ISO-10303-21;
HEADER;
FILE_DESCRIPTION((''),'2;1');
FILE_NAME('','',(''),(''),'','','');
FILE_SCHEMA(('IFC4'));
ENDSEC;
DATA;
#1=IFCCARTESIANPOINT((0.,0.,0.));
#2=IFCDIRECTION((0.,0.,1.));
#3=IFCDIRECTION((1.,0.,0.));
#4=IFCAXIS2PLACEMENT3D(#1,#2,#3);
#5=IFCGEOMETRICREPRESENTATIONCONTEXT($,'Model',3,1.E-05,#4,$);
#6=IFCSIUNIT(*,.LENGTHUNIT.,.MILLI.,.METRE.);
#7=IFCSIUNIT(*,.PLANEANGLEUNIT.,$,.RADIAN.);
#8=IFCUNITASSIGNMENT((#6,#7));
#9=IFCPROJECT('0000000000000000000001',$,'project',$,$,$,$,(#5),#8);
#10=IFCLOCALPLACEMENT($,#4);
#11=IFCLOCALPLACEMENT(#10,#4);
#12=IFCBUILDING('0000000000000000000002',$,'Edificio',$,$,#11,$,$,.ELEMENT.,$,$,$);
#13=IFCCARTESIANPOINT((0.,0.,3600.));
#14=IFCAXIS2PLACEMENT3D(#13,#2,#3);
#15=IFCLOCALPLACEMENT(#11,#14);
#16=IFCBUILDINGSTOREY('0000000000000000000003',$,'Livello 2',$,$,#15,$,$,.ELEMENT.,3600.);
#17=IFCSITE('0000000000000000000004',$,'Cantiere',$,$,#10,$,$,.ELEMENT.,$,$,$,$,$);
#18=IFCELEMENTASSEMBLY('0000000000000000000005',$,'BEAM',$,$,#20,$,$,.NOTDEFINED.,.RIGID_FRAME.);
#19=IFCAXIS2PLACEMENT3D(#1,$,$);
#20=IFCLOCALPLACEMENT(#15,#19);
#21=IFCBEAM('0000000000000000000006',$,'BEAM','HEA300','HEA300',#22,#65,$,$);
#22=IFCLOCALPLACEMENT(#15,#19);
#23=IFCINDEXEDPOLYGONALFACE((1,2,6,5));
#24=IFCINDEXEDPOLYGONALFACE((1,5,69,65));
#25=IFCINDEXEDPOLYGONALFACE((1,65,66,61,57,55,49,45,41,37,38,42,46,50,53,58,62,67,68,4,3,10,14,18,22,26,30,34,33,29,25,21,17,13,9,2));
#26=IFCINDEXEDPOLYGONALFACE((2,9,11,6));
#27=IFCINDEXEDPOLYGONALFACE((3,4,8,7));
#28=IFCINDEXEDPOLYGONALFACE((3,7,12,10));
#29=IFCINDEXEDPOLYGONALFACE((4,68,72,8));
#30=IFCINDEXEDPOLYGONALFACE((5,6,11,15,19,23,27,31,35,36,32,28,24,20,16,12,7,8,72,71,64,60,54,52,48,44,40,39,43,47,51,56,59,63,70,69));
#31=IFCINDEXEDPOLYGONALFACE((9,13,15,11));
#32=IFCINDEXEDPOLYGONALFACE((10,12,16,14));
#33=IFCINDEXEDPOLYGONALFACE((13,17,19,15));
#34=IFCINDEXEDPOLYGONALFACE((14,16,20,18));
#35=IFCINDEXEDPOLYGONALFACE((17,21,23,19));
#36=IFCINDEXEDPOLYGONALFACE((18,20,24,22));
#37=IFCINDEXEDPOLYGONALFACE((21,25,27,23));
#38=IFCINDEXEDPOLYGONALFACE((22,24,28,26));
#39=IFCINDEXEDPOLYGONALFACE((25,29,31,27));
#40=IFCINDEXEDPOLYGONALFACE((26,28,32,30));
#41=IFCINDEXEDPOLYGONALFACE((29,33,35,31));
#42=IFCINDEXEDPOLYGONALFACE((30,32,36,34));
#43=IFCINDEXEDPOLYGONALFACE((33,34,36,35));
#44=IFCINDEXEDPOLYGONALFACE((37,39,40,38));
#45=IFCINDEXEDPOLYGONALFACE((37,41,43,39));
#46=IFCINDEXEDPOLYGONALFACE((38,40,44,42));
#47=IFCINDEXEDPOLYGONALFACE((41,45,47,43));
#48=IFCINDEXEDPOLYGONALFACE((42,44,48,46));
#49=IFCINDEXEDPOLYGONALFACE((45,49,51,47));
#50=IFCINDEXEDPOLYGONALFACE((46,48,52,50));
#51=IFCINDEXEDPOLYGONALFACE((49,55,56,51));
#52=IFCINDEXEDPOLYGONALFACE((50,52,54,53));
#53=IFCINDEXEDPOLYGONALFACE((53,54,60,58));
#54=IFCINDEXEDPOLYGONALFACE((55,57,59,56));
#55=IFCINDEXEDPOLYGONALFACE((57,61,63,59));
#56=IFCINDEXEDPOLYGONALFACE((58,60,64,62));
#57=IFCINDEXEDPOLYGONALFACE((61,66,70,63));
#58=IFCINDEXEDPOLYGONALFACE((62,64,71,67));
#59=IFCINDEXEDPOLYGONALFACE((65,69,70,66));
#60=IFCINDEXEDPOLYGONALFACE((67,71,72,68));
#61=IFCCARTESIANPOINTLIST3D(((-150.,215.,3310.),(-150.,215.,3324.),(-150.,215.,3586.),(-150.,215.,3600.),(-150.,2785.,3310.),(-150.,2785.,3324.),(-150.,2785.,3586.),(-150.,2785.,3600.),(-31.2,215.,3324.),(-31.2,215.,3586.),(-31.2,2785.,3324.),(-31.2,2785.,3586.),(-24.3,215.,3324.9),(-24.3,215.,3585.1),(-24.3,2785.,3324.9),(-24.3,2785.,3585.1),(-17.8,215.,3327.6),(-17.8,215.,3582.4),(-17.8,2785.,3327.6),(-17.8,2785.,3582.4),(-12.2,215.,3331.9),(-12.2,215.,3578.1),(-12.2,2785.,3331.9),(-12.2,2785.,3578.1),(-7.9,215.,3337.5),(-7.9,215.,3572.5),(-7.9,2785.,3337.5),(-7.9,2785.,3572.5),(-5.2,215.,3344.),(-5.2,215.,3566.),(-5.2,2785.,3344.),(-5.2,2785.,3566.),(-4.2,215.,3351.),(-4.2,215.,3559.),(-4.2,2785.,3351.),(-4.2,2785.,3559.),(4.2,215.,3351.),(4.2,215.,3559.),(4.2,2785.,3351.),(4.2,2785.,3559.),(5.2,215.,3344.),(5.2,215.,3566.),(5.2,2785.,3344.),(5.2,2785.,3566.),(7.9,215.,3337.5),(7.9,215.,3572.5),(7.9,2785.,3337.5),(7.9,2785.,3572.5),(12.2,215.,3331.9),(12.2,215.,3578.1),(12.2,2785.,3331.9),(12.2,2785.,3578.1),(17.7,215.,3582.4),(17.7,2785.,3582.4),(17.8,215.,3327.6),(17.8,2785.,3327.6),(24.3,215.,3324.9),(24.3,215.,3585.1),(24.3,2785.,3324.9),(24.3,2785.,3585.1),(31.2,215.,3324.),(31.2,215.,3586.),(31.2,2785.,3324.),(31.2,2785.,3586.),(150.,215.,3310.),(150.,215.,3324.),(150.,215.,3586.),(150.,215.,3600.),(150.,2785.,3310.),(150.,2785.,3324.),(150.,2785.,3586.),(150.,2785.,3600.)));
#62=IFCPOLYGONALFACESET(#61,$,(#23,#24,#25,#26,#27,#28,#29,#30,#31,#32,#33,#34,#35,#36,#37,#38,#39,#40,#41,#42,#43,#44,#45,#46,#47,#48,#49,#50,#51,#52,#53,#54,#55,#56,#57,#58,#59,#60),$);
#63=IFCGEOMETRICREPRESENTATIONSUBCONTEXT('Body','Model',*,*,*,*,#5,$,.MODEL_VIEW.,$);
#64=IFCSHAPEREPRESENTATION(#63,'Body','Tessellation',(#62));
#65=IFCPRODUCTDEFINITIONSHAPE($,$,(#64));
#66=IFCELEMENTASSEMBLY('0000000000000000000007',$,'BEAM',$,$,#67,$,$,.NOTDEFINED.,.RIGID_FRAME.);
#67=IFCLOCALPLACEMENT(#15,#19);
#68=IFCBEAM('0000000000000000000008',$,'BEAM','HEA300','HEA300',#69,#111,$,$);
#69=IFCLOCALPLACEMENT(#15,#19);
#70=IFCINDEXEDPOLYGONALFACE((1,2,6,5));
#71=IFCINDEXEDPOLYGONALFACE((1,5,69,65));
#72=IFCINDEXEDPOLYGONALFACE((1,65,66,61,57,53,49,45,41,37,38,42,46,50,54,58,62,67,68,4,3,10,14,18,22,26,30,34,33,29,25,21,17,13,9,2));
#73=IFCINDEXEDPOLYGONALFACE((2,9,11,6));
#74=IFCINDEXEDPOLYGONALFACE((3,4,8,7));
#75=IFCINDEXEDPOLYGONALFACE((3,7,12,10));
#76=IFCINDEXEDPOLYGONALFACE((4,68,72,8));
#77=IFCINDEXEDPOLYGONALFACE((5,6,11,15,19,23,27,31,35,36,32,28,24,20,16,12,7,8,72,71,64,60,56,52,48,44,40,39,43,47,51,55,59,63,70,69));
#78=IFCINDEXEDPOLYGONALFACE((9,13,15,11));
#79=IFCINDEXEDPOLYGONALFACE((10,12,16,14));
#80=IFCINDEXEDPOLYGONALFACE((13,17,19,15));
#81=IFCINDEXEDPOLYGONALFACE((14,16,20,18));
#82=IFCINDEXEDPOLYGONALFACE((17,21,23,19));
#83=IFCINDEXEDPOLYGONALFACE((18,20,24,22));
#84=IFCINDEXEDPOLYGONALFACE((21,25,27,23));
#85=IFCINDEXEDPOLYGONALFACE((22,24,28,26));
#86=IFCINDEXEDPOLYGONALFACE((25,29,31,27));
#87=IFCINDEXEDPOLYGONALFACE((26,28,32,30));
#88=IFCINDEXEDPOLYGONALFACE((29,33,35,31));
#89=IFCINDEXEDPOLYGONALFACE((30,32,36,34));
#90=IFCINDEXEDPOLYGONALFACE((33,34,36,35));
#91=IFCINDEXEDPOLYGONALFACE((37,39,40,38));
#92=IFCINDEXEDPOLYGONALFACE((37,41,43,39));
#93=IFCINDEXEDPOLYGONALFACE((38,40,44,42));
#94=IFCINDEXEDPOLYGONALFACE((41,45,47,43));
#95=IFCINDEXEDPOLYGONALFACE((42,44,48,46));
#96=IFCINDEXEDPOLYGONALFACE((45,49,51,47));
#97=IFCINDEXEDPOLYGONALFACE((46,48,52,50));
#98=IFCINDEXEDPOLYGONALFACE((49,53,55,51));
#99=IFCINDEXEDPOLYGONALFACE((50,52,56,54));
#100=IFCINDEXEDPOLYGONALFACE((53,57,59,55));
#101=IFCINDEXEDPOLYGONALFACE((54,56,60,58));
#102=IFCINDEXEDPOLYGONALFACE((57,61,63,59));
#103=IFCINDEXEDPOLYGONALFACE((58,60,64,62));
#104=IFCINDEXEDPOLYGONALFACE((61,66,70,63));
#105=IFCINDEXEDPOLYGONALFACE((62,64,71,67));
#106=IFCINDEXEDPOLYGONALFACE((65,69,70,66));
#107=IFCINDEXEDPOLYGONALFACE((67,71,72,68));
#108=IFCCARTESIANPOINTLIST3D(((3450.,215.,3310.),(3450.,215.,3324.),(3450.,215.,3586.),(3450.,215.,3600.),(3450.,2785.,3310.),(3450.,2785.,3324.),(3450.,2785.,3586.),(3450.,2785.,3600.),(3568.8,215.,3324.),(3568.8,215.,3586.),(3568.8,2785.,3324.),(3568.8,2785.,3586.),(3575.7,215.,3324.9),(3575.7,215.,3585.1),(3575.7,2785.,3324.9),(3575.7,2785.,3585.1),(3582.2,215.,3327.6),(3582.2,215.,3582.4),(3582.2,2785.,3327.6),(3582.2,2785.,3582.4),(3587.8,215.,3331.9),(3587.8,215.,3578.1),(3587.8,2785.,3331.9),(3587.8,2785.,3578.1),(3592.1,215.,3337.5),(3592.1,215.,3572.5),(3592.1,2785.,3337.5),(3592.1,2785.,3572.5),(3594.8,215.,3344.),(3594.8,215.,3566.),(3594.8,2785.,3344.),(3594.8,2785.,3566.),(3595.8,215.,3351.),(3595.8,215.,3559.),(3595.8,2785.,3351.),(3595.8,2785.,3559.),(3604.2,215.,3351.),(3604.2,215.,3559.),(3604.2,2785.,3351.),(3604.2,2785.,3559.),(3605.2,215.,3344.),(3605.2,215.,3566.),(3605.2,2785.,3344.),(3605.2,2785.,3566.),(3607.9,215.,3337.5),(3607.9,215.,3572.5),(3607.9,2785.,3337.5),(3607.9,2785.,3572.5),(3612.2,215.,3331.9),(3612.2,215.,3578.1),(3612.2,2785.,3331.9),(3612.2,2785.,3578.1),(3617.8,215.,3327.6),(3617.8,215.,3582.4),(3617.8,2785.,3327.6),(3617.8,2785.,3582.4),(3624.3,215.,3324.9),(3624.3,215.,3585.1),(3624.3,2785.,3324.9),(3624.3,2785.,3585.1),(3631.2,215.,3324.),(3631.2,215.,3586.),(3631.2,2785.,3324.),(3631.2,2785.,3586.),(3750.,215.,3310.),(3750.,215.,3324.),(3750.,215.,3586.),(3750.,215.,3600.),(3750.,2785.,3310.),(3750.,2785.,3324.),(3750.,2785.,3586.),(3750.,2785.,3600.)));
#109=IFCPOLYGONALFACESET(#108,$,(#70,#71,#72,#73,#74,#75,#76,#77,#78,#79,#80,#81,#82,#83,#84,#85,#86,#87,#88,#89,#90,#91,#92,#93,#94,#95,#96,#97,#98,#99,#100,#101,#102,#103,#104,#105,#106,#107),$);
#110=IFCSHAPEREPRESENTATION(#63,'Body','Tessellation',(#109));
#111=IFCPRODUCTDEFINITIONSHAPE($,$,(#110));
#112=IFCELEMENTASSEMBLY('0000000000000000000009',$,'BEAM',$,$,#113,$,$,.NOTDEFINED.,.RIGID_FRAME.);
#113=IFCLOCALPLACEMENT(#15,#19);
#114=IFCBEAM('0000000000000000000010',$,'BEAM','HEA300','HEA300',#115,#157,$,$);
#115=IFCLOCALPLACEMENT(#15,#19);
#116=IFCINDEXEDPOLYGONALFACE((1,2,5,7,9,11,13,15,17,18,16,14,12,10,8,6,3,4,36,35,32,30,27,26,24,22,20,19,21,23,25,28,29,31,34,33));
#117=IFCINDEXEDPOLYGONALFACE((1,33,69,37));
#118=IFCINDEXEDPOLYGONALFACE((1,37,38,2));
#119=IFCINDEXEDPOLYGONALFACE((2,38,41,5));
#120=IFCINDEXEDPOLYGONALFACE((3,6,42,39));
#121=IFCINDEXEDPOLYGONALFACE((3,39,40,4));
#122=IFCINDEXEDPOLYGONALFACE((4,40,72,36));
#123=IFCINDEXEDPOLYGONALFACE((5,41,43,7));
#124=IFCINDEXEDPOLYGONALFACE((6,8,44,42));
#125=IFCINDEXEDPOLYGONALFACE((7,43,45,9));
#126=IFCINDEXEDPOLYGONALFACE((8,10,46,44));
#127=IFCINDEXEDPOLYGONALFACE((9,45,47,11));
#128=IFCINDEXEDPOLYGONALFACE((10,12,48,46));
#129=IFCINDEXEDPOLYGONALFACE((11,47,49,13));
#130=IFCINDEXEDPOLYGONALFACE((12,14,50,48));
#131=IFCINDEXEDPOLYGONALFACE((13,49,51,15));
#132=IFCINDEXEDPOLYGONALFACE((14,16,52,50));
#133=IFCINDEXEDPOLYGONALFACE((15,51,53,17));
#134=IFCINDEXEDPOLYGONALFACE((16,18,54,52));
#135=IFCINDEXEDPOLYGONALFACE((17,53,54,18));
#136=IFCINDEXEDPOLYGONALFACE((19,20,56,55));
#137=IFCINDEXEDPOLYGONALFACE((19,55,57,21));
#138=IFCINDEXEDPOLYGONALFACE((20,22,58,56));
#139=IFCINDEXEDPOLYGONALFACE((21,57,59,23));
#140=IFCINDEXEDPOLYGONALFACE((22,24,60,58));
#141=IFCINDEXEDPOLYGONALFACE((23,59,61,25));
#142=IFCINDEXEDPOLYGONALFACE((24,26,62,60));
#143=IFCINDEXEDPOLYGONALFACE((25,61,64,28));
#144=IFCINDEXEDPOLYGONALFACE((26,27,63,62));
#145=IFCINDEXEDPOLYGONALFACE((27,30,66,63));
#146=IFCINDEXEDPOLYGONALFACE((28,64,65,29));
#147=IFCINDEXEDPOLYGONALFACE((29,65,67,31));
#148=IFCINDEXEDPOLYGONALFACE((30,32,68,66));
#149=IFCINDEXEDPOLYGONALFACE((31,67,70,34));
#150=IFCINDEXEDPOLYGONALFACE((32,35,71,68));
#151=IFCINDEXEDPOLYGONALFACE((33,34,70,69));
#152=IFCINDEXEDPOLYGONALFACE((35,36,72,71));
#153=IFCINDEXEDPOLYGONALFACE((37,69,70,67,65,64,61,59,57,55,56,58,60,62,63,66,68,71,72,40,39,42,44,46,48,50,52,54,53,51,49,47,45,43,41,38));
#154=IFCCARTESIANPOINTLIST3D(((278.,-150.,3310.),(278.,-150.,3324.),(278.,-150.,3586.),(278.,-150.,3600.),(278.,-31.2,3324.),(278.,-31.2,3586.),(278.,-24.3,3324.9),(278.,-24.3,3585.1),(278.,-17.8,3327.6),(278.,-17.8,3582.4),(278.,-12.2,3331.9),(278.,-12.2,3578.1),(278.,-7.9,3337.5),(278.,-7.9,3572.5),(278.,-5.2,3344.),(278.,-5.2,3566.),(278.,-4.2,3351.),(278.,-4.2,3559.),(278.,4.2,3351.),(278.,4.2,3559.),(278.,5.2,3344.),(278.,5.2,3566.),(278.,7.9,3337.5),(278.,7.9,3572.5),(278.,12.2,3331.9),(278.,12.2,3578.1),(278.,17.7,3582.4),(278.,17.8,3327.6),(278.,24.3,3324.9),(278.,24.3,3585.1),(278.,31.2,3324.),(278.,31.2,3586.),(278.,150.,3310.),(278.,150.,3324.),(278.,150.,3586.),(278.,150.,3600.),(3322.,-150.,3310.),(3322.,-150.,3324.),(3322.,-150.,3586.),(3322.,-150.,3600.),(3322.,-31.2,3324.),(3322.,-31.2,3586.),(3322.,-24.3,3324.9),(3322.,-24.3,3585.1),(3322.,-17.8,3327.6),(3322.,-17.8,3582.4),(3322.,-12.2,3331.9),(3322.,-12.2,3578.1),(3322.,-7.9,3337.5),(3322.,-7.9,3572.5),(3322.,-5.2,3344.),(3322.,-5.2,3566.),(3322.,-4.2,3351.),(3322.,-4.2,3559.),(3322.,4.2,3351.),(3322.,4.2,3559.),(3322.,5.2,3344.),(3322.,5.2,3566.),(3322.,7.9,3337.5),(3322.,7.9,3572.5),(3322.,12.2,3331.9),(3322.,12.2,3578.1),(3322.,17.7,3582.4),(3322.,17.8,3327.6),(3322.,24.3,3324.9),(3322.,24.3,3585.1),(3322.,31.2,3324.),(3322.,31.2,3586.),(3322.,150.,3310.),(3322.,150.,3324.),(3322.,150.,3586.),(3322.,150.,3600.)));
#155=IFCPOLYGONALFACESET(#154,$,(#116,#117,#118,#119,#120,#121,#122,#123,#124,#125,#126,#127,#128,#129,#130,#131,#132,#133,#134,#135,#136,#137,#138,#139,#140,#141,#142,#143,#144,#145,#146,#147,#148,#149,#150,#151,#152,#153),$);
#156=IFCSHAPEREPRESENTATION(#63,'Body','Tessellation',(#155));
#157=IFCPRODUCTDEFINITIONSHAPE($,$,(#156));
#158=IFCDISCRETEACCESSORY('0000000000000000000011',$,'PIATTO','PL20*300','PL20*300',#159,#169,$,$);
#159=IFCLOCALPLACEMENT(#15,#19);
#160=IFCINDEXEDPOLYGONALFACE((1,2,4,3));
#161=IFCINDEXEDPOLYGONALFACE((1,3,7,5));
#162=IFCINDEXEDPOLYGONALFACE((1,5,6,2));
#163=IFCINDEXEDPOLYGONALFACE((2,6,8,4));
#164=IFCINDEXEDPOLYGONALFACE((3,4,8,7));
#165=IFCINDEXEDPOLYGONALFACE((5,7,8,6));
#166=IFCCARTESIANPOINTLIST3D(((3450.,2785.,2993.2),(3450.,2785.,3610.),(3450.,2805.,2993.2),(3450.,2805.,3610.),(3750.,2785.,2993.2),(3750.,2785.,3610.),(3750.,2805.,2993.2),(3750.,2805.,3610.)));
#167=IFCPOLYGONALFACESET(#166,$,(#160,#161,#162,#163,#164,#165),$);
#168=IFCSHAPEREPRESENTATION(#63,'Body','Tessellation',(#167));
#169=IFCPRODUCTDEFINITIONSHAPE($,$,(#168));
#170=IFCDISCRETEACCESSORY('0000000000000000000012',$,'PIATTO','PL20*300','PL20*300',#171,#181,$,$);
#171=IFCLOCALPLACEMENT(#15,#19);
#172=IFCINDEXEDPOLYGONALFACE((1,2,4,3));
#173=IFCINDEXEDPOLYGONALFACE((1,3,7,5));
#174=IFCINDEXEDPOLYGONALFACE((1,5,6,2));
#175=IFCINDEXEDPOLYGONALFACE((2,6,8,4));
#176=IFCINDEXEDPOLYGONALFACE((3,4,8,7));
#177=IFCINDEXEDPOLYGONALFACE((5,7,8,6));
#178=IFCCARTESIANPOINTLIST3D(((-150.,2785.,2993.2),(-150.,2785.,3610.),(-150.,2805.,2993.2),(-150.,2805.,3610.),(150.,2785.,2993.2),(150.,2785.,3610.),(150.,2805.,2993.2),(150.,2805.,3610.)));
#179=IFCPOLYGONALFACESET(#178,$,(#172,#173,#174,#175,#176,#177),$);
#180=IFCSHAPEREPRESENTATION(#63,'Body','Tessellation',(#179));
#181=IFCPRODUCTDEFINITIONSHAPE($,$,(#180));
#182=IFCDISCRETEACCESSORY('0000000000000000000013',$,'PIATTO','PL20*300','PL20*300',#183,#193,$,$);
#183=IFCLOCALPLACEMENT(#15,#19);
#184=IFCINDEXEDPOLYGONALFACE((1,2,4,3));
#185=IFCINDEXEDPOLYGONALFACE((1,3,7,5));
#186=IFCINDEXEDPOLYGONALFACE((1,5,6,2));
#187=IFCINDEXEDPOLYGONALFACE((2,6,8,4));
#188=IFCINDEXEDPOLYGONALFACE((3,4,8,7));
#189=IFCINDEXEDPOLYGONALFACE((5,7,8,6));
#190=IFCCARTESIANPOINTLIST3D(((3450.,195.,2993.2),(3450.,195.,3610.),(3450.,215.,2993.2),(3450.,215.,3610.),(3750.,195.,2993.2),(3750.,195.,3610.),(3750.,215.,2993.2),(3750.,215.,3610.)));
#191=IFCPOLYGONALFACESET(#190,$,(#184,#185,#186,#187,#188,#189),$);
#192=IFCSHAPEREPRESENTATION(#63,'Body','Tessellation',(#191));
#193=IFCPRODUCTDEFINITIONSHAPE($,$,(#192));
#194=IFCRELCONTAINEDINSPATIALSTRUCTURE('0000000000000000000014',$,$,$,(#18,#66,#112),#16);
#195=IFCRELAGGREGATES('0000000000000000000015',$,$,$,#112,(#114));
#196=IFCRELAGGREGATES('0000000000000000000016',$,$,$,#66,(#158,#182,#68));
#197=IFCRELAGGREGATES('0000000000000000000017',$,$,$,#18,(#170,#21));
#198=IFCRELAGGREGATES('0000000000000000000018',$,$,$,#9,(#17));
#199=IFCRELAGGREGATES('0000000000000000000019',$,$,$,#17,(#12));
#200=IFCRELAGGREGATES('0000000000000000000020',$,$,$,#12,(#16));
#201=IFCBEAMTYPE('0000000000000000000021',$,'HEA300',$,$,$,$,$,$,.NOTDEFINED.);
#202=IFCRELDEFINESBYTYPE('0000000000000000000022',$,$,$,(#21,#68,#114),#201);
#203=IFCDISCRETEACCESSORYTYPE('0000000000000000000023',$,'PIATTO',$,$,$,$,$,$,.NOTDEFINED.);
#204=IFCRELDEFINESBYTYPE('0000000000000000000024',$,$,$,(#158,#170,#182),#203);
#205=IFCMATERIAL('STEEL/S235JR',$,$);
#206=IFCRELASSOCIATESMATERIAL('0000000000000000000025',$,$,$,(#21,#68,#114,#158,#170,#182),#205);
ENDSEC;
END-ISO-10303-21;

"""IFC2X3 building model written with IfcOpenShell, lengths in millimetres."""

from ifc_helpers import new_model, si_unit, frame, origin_with_axes, origin_2d_with_axis, place, context, subcontext, project, spatial, polyline, i_section, outline, extrude, clip, halfspace, material, type_object, element, aggregate, save


model = new_model("IFC2X3")

# Units and contexts
model_context = context("Model", 3, precision=1e-05, world=origin_with_axes())
body_context = subcontext(model_context, "Body", "Model", "MODEL_VIEW")
ifc_project = project(units=[si_unit("LENGTHUNIT", "METRE", prefix="MILLI"), si_unit("PLANEANGLEUNIT", "RADIAN")], contexts=[model_context])

# Site, building, storey
site_placement = place(None, origin_with_axes())
site = spatial("IfcSite", under=ifc_project, at=site_placement, Name="Cantiere", CompositionType="ELEMENT")
building_placement = place(site_placement, origin_with_axes())
building = spatial("IfcBuilding", under=site, at=building_placement, Name="Edificio", CompositionType="ELEMENT")
storey_placement = place(building_placement, frame((0.0, 0.0, 3600.0), z_axis=(0.0, 0.0, 1.0), x_axis=(1.0, 0.0, 0.0)))
storey = spatial("IfcBuildingStorey", under=building, at=storey_placement, Name="Livello 2", CompositionType="ELEMENT", Elevation=3600.0)

# Element assemblies, beams
assembly_1_placement = place(storey_placement, origin_with_axes())
assembly_1 = element("IfcElementAssembly", 1, at=assembly_1_placement, inside=storey, Name="BEAM", AssemblyPlace="NOTDEFINED", PredefinedType="RIGID_FRAME")
ifc_material_1 = material(Name="STEEL/S235JR")
beam_type = type_object("IfcBeamType", Name="HEA300", PredefinedType="NOTDEFINED")
beam_1_placement = place(assembly_1_placement, frame((0.0, 3000.0, 3455.0), z_axis=(0.0, 0.0, 1.0), x_axis=(0.0, -1.0, 0.0)))
beam_1 = element("IfcBeam", 2, at=beam_1_placement, type_object=beam_type, material=ifc_material_1, Name="BEAM", Description="HEA300", ObjectType="HEA300", context=body_context, shape_type="Clipping", body=[
    clip(clip(extrude(i_section(OverallWidth=300.0, OverallDepth=290.0, WebThickness=8.5, FlangeThickness=14.0, FilletRadius=27.0, at=origin_2d_with_axis()), frame((2785.0, 0.0, 0.0), z_axis=(-1.0, 0.0, 0.0), x_axis=(0.0, -1.0, 0.0)), (0.0, 0.0, 1.0), 2570.0), halfspace(frame((2785.0, 0.0, -145.0), z_axis=(-1.0, 0.0, 0.0), x_axis=(0.0, 1.0, 0.0)), True)), halfspace(frame((215.0, 0.0, -145.0), z_axis=(1.0, 0.0, 0.0), x_axis=(0.0, -1.0, 0.0)), True)),
])
assembly_2_placement = place(storey_placement, origin_with_axes())
assembly_2 = element("IfcElementAssembly", 3, at=assembly_2_placement, inside=storey, Name="BEAM", AssemblyPlace="NOTDEFINED", PredefinedType="RIGID_FRAME")
beam_2_placement = place(assembly_2_placement, frame((3600.0, 3000.0, 3455.0), z_axis=(0.0, 0.0, 1.0), x_axis=(0.0, -1.0, 0.0)))
beam_2 = element("IfcBeam", 4, at=beam_2_placement, type_object=beam_type, material=ifc_material_1, Name="BEAM", Description="HEA300", ObjectType="HEA300", context=body_context, shape_type="Clipping", body=[
    clip(clip(extrude(i_section(OverallWidth=300.0, OverallDepth=290.0, WebThickness=8.5, FlangeThickness=14.0, FilletRadius=27.0, at=origin_2d_with_axis()), frame((2785.0, 0.0, 0.0), z_axis=(-1.0, 0.0, 0.0), x_axis=(0.0, -1.0, 0.0)), (0.0, 0.0, 1.0), 2570.0), halfspace(frame((2785.0, 0.0, -145.0), z_axis=(-1.0, 0.0, 0.0), x_axis=(0.0, 1.0, 0.0)), True)), halfspace(frame((215.0, 0.0, -145.0), z_axis=(1.0, 0.0, 0.0), x_axis=(0.0, -1.0, 0.0)), True)),
])
assembly_3_placement = place(storey_placement, origin_with_axes())
assembly_3 = element("IfcElementAssembly", 5, at=assembly_3_placement, inside=storey, Name="BEAM", AssemblyPlace="NOTDEFINED", PredefinedType="RIGID_FRAME")
beam_3_placement = place(assembly_3_placement, frame((0.0, 0.0, 3455.0), z_axis=(0.0, 0.0, 1.0), x_axis=(1.0, 0.0, 0.0)))
beam_3 = element("IfcBeam", 6, at=beam_3_placement, type_object=beam_type, material=ifc_material_1, Name="BEAM", Description="HEA300", ObjectType="HEA300", context=body_context, shape_type="Clipping", body=[
    clip(clip(extrude(i_section(OverallWidth=300.0, OverallDepth=290.0, WebThickness=8.5, FlangeThickness=14.0, FilletRadius=27.0, at=origin_2d_with_axis()), frame((3322.0, 0.0, 0.0), z_axis=(-1.0, 0.0, 0.0), x_axis=(0.0, -1.0, 0.0)), (0.0, 0.0, 1.0), 3044.0), halfspace(frame((3322.0, -150.0, 0.0), z_axis=(1.0, 0.0, 0.0), x_axis=(0.0, 0.0, 1.0)), False)), halfspace(frame((278.0, 150.0, 0.0), z_axis=(-1.0, 0.0, 0.0), x_axis=(0.0, 0.0, 1.0)), False)),
])

# Discrete accessories
discrete_accessory_type_1 = type_object("IfcDiscreteAccessoryType", Name="PIATTO")
discrete_accessory_1_placement = place(assembly_2_placement, frame((3600.0, 2795.0, 2993.2), z_axis=(0.0, -1.0, 0.0), x_axis=(0.0, 0.0, 1.0)))
discrete_accessory_1 = element("IfcDiscreteAccessory", 7, at=discrete_accessory_1_placement, type_object=discrete_accessory_type_1, material=ifc_material_1, Name="PIATTO", Description="PL20*300", ObjectType="PL20*300", context=body_context, shape_type="SweptSolid", body=[
    extrude(outline(polyline([(0.0, 150.0), (616.8, 150.0), (616.8, -150.0), (0.0, -150.0), (0.0, 150.0)])), frame((0.0, 0.0, -10.0), z_axis=(0.0, 0.0, 1.0), x_axis=(1.0, 0.0, 0.0)), (0.0, 0.0, 1.0), 20.0),
])
discrete_accessory_2_placement = place(assembly_1_placement, frame((0.0, 2795.0, 2993.2), z_axis=(0.0, -1.0, 0.0), x_axis=(0.0, 0.0, 1.0)))
discrete_accessory_2 = element("IfcDiscreteAccessory", 8, at=discrete_accessory_2_placement, type_object=discrete_accessory_type_1, material=ifc_material_1, Name="PIATTO", Description="PL20*300", ObjectType="PL20*300", context=body_context, shape_type="SweptSolid", body=[
    extrude(outline(polyline([(0.0, 150.0), (616.8, 150.0), (616.8, -150.0), (0.0, -150.0), (0.0, 150.0)])), frame((0.0, 0.0, -10.0), z_axis=(0.0, 0.0, 1.0), x_axis=(1.0, 0.0, 0.0)), (0.0, 0.0, 1.0), 20.0),
])
discrete_accessory_3_placement = place(assembly_2_placement, frame((3600.0, 205.0, 2993.2), z_axis=(0.0, 1.0, 0.0), x_axis=(0.0, 0.0, 1.0)))
discrete_accessory_3 = element("IfcDiscreteAccessory", 9, at=discrete_accessory_3_placement, type_object=discrete_accessory_type_1, material=ifc_material_1, Name="PIATTO", Description="PL20*300", ObjectType="PL20*300", context=body_context, shape_type="SweptSolid", body=[
    extrude(outline(polyline([(0.0, -150.0), (0.0, 150.0), (616.8, 150.0), (616.8, -150.0), (0.0, -150.0)])), frame((0.0, 0.0, -10.0), z_axis=(0.0, 0.0, 1.0), x_axis=(1.0, 0.0, 0.0)), (0.0, 0.0, 1.0), 20.0),
])

aggregate(assembly_3, [beam_3])

aggregate(assembly_2, [discrete_accessory_1, discrete_accessory_3, beam_2])
aggregate(assembly_1, [discrete_accessory_2, beam_1])

save(model, "model.ifc")
